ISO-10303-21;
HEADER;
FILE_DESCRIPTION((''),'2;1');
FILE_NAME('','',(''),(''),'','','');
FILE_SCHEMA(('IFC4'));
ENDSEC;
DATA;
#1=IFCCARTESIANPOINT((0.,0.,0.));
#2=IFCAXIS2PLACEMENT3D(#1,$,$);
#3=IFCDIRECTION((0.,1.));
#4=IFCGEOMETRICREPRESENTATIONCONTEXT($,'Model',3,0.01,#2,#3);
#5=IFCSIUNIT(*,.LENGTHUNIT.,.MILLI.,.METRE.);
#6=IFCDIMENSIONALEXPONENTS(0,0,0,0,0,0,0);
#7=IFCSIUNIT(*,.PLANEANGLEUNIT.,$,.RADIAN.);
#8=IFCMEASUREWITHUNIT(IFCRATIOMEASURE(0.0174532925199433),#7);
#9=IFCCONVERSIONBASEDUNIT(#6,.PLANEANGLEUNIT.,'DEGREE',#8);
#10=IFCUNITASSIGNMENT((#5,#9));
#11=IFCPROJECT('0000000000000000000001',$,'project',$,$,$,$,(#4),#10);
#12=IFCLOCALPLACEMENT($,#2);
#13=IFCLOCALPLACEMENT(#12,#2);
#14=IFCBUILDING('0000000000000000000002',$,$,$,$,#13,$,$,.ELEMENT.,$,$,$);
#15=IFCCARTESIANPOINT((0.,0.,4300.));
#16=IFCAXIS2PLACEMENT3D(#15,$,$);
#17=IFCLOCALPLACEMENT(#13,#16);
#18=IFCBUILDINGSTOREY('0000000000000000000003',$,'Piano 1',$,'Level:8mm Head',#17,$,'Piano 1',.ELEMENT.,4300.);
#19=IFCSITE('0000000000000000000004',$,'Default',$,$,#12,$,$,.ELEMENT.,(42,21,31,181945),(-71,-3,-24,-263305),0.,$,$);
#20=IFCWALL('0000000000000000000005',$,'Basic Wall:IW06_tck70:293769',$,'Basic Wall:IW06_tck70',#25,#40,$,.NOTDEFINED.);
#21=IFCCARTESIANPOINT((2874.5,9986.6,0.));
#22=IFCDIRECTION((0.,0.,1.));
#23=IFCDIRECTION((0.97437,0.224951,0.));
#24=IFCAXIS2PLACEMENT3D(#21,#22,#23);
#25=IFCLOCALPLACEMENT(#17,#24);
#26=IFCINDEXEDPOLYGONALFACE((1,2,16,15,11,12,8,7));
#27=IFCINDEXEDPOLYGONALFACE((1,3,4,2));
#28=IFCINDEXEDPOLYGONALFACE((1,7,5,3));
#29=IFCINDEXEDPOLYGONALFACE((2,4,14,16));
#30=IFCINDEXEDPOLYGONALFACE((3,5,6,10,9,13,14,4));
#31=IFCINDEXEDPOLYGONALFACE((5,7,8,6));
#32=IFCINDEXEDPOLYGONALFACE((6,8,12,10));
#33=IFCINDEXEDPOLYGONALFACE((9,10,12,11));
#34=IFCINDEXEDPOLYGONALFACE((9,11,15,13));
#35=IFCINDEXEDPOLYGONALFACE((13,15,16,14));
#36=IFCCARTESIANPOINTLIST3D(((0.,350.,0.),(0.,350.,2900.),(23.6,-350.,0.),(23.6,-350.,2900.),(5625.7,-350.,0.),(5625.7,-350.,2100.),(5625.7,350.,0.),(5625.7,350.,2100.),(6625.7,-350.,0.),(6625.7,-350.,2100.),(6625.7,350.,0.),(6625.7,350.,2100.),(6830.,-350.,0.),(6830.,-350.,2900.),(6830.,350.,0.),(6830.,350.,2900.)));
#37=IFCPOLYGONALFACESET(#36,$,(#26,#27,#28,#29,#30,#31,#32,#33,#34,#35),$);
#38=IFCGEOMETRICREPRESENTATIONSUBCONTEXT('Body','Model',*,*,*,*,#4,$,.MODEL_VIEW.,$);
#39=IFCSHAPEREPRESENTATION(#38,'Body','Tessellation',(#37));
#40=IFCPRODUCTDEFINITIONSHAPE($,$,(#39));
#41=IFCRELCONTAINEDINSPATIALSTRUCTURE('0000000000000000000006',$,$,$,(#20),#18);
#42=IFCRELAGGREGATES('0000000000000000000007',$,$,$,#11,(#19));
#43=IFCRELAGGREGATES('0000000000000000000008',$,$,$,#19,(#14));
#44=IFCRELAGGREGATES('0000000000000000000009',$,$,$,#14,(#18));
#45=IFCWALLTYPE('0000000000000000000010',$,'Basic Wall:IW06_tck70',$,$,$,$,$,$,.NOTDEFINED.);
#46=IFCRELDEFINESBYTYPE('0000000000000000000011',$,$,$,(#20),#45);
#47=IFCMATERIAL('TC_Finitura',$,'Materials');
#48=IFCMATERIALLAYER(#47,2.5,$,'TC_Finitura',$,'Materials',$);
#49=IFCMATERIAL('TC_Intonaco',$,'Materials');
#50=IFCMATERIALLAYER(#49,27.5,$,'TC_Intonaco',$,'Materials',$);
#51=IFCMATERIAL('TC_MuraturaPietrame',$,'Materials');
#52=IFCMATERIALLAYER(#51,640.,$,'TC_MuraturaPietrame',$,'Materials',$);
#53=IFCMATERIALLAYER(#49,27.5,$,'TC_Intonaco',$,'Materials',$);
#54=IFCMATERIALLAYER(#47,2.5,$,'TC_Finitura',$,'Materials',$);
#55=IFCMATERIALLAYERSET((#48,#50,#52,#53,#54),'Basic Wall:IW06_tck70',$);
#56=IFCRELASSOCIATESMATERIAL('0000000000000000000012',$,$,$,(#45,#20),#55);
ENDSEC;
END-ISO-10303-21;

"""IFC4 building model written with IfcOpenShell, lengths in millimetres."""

from ifc_helpers import new_model, entity, si_unit, converted_unit, direction, frame, frame_2d, origin, place, context, subcontext, project, spatial, polyline, rectangle, outline, extrude, clip, bounded_halfspace, material, layer, layer_set, layer_usage, type_object, element, save


model = new_model("IFC4")

# Units and contexts
model_context = context("Model", 3, precision=0.01, world=origin(), true_north=direction((0.0, 1.0)))
body_context = subcontext(model_context, "Body", "Model", "MODEL_VIEW")
ifc_project = project(units=[si_unit("LENGTHUNIT", "METRE", prefix="MILLI"), converted_unit("PLANEANGLEUNIT", "DEGREE", entity("IfcRatioMeasure", 0.0174532925199433), si_unit("PLANEANGLEUNIT", "RADIAN"), dimensions=[0, 0, 0, 0, 0, 0, 0])], contexts=[model_context])

# Site, building, storey
site_placement = place(None, origin())
site = spatial("IfcSite", under=ifc_project, at=site_placement, Name="Default", CompositionType="ELEMENT", RefLatitude=(42, 21, 31, 181945), RefLongitude=(-71, -3, -24, -263305), RefElevation=0.0)
building_placement = place(site_placement, origin())
building = spatial("IfcBuilding", under=site, at=building_placement, CompositionType="ELEMENT")
storey_placement = place(building_placement, frame((0.0, 0.0, 4300.0)))
storey = spatial("IfcBuildingStorey", under=building, at=storey_placement, Name="Piano 1", ObjectType="Level:8mm Head", LongName="Piano 1", CompositionType="ELEMENT", Elevation=4300.0)

# Shared definitions
ifc_material_1 = material(Name="TC_Finitura", Category="Materials")
ifc_material_2 = material(Name="TC_Intonaco", Category="Materials")
ifc_material_3 = material(Name="TC_MuraturaPietrame", Category="Materials")

# Wall, opening
ifc_layer_1 = layer(ifc_material_1, 2.5, Name="TC_Finitura", Category="Materials")
ifc_layer_2 = layer(ifc_material_2, 27.5, Name="TC_Intonaco", Category="Materials")
ifc_layer_3 = layer(ifc_material_3, 640.0, Name="TC_MuraturaPietrame", Category="Materials")
ifc_layer_4 = layer(ifc_material_2, 27.5, Name="TC_Intonaco", Category="Materials")
ifc_layer_5 = layer(ifc_material_1, 2.5, Name="TC_Finitura", Category="Materials")
ifc_layer_set_1 = layer_set([ifc_layer_1, ifc_layer_2, ifc_layer_3, ifc_layer_4, ifc_layer_5], Name="Basic Wall:IW06_tck70")
wall_type_1 = type_object("IfcWallType", Name="Basic Wall:IW06_tck70", PredefinedType="NOTDEFINED", material=ifc_layer_set_1)
ifc_layer_usage_1 = layer_usage(ifc_layer_set_1, "AXIS2", "NEGATIVE", 350.0)
wall_1_placement = place(storey_placement, frame((2874.5, 9986.6, 0.0), z_axis=(0.0, 0.0, 1.0), x_axis=(0.97437, 0.224951, 0.0)))
wall_1 = element("IfcWall", 1, at=wall_1_placement, inside=storey, type_object=wall_type_1, material=ifc_layer_usage_1, Name="Basic Wall:IW06_tck70:293769", ObjectType="Basic Wall:IW06_tck70", PredefinedType="NOTDEFINED", context=body_context, shape_type="Clipping", body=[
    clip(extrude(outline(polyline([(23.6, -350.0), (824.1, -350.0), (4381.0, -350.0), (4531.0, -350.0), (6830.0, -350.0), (6830.0, 350.0), (5420.7, 350.0), (5270.7, 350.0), (810.8, 350.0), (0.0, 350.0), (23.6, -350.0)])), origin(), (0.0, 0.0, 1.0), 2900.0), bounded_halfspace(frame((23.6, -350.0, 2900.0), z_axis=(0.0, 0.0, -1.0), x_axis=(0.998882, 0.04728, 0.0)), True, frame((23.6, -350.0, 2900.0)), polyline([(0.0, 0.0), (800.5, 0.0), (4357.4, 0.0), (4507.4, 0.0), (6806.4, 0.0), (6806.4, 700.0), (5397.1, 700.0), (5247.1, 700.0), (787.2, 700.0), (-23.6, 700.0), (0.0, 0.0)]))),
])
opening_1_placement = place(wall_1_placement, frame((5625.7, -350.0, 0.0)))
element("IfcOpeningElement", 2, at=opening_1_placement, cuts=wall_1, ObjectType="Opening", PredefinedType="OPENING", context=body_context, shape_type="SweptSolid", body=[
    extrude(rectangle(XDim=2100.0, YDim=1000.0, at=frame_2d((1050.0, 500.0), x_axis=(1.0, 0.0))), frame((0.0, 0.0, 0.0), z_axis=(0.0, 1.0, 0.0), x_axis=(0.0, 0.0, 1.0)), (0.0, 0.0, 1.0), 700.0),
])

save(model, "model.ifc")
